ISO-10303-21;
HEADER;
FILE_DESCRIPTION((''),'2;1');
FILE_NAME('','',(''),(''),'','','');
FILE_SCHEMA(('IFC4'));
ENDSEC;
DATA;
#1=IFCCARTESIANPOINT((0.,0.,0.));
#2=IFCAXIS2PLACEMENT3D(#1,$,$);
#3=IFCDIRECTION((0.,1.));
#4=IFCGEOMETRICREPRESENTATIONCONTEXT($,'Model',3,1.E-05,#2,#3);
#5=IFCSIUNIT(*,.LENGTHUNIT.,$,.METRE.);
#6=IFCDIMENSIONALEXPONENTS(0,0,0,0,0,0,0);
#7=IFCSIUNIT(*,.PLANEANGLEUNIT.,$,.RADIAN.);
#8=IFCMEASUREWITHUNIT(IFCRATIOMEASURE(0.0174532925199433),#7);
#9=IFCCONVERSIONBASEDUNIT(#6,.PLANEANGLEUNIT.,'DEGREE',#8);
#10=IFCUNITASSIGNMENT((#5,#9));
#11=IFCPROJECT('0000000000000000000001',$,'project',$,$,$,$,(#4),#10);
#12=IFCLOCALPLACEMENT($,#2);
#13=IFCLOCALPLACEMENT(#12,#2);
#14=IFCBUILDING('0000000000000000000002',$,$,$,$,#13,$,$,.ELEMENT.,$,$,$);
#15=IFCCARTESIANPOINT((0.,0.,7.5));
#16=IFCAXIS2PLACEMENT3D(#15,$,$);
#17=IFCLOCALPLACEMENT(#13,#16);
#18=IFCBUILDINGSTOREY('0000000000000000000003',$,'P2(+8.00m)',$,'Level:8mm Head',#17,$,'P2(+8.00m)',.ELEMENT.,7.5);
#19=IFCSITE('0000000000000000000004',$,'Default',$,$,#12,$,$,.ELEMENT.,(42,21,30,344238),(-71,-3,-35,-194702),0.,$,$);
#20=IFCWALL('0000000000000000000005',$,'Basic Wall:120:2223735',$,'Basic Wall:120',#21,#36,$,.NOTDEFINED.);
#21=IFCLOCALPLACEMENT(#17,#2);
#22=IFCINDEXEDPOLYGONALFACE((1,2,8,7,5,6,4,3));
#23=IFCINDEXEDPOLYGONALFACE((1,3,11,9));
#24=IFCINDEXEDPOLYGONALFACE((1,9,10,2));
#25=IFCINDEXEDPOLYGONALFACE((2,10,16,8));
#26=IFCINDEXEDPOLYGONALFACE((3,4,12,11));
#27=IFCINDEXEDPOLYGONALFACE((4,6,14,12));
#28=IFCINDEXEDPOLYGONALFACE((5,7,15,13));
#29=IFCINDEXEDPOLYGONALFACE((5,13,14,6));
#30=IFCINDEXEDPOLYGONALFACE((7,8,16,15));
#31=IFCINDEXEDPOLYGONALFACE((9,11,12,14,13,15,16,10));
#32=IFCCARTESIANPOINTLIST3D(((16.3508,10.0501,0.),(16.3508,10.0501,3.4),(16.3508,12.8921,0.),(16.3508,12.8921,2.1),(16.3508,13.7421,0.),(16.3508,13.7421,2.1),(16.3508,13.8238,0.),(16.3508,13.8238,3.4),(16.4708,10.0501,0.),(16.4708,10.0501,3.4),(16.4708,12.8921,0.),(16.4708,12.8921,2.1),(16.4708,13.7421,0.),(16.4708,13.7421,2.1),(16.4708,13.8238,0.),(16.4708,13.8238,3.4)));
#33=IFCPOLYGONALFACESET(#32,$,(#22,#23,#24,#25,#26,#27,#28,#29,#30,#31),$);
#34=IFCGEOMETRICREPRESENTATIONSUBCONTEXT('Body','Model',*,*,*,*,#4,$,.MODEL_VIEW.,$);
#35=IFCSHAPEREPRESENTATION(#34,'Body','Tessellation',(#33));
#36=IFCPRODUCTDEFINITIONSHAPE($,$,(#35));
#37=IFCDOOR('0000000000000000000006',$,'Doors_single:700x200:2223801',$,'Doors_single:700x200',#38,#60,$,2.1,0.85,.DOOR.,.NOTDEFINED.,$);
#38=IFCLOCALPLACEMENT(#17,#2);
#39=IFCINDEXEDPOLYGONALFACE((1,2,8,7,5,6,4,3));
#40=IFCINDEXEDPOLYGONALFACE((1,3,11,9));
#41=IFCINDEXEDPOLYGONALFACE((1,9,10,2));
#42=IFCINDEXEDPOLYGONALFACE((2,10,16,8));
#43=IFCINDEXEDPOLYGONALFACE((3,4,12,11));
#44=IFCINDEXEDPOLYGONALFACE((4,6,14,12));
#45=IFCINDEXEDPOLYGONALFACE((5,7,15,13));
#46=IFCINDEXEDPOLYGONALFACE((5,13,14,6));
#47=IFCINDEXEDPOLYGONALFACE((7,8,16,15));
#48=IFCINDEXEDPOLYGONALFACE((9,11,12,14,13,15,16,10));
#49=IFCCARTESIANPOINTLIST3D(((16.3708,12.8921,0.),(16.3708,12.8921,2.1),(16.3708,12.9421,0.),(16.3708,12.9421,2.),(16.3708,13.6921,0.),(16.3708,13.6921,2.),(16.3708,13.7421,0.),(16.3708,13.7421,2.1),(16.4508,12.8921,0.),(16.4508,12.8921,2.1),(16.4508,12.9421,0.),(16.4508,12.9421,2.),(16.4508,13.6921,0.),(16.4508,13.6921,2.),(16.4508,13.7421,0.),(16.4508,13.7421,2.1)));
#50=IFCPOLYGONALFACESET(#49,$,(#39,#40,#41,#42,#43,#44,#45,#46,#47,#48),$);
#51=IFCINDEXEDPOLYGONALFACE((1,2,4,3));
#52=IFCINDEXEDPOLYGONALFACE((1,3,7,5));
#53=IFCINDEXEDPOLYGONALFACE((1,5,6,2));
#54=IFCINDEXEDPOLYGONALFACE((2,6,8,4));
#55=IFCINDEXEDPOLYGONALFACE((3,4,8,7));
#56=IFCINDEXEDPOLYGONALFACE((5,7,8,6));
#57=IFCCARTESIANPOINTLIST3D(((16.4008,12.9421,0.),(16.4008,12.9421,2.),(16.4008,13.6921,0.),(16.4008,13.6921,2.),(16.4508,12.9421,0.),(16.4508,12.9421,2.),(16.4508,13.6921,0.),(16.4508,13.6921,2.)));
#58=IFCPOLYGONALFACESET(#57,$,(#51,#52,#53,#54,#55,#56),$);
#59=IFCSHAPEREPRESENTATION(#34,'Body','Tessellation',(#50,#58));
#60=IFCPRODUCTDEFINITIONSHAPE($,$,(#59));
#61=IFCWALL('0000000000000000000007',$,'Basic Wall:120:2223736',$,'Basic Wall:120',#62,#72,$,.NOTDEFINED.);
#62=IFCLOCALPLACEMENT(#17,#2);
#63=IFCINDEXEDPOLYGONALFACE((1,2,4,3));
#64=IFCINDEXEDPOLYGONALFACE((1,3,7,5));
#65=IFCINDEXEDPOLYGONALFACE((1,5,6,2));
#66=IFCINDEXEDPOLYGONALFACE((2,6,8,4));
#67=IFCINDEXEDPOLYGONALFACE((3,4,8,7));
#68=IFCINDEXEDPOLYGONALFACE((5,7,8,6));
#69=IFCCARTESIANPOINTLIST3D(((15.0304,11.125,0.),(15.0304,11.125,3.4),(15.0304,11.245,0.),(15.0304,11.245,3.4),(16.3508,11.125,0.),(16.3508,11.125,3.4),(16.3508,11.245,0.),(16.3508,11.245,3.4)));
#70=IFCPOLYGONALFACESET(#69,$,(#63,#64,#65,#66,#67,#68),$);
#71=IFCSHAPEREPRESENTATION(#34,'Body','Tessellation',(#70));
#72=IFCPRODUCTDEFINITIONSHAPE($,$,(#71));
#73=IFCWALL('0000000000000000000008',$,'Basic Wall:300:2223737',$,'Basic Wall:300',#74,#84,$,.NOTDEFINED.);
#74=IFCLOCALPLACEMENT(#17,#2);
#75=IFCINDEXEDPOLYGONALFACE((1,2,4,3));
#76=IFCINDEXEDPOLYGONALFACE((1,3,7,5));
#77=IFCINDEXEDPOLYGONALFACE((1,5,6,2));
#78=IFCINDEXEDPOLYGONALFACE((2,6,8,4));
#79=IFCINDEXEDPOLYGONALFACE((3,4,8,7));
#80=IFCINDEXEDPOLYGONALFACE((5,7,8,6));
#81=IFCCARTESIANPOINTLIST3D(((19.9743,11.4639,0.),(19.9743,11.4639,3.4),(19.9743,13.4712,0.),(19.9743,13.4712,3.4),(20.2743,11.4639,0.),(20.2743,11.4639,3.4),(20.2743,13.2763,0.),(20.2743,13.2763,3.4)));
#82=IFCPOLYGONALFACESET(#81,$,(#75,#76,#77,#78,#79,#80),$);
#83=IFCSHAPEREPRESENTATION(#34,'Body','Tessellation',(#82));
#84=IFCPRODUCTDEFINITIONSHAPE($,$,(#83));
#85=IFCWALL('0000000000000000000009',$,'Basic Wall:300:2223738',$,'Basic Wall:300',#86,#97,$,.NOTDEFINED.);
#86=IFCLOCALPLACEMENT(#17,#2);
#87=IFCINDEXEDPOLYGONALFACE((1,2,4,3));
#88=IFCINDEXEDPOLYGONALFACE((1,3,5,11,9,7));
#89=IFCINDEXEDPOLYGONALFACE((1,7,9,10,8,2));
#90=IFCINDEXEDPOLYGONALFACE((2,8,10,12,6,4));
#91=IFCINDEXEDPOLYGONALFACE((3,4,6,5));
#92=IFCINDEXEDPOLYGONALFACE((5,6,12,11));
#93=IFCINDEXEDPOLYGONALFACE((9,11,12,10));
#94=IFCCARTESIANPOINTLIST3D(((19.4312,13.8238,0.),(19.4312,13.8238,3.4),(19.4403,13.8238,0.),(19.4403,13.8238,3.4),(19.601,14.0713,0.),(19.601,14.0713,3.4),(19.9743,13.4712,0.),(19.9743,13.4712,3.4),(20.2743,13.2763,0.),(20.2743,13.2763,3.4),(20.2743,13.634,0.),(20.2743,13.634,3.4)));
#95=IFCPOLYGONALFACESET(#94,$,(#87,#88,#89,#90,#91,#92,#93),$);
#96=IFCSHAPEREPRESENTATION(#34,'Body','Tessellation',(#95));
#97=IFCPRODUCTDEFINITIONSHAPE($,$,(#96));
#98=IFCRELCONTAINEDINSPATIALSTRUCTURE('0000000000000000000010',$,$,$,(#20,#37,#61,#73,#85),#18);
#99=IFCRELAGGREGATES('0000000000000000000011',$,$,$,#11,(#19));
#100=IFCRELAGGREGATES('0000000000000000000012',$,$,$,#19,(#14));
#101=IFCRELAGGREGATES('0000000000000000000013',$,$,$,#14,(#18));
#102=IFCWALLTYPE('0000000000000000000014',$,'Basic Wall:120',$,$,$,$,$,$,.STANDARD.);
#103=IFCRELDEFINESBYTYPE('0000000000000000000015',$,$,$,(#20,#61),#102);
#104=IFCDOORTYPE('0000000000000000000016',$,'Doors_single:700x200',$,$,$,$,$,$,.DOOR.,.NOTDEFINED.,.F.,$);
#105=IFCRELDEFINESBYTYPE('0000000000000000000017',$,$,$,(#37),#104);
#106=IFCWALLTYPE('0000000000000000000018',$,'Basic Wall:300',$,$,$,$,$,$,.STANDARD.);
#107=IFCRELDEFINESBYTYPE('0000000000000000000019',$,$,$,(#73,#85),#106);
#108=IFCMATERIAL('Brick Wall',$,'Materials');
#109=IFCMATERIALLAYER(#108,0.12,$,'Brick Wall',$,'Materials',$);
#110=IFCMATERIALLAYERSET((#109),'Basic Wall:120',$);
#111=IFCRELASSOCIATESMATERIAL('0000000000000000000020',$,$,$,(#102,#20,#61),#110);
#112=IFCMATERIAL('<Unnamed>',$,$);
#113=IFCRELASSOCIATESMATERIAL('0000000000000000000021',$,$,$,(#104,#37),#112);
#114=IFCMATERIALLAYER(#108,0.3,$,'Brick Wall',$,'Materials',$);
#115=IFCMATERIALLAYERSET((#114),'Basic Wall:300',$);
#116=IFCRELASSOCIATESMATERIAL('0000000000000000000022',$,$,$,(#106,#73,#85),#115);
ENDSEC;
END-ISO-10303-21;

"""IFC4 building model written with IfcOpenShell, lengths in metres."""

from ifc_helpers import new_model, entity, si_unit, converted_unit, direction, frame, frame_2d, origin, origin_2d_with_axis, place, context, subcontext, project, spatial, polyline, rectangle, outline, extrude, source, transform, mapped, material, layer, layer_set, layer_usage, type_object, type_shapes, element, fill, save


model = new_model("IFC4")

# Units and contexts
model_context = context("Model", 3, precision=1e-05, world=origin(), true_north=direction((0.0, 1.0)))
body_context = subcontext(model_context, "Body", "Model", "MODEL_VIEW")
ifc_project = project(units=[si_unit("LENGTHUNIT", "METRE"), converted_unit("PLANEANGLEUNIT", "DEGREE", entity("IfcRatioMeasure", 0.0174532925199433), si_unit("PLANEANGLEUNIT", "RADIAN"), dimensions=[0, 0, 0, 0, 0, 0, 0])], contexts=[model_context])

# Site, building, storey
site_placement = place(None, origin())
site = spatial("IfcSite", under=ifc_project, at=site_placement, Name="Default", CompositionType="ELEMENT", RefLatitude=(42, 21, 30, 344238), RefLongitude=(-71, -3, -35, -194702), RefElevation=0.0)
building_placement = place(site_placement, origin())
building = spatial("IfcBuilding", under=site, at=building_placement, CompositionType="ELEMENT")
storey_placement = place(building_placement, frame((0.0, 0.0, 7.5)))
storey = spatial("IfcBuildingStorey", under=building, at=storey_placement, Name="P2(+8.00m)", ObjectType="Level:8mm Head", LongName="P2(+8.00m)", CompositionType="ELEMENT", Elevation=7.5)

# Shared definitions
ifc_material_1 = material(Name="Brick Wall", Category="Materials")

# Shared definitions
ifc_material_2 = material(Name="<Unnamed>")

# Wall, opening, door
ifc_layer_1 = layer(ifc_material_1, 0.12, Name="Brick Wall", Category="Materials")
ifc_layer_set_1 = layer_set([ifc_layer_1], Name="Basic Wall:120")
ifc_layer_usage_1 = layer_usage(ifc_layer_set_1, "AXIS2", "POSITIVE", -0.06)
wall_type_1 = type_object("IfcWallType", Name="Basic Wall:120", PredefinedType="STANDARD", material=ifc_layer_set_1)
wall_1_placement = place(storey_placement, frame((16.4108, 10.0501, 0.0), z_axis=(0.0, 0.0, 1.0), x_axis=(0.0, 1.0, 0.0)))
wall_1 = element("IfcWall", 1, at=wall_1_placement, inside=storey, type_object=wall_type_1, material=ifc_layer_usage_1, Name="Basic Wall:120:2223735", ObjectType="Basic Wall:120", PredefinedType="NOTDEFINED", context=body_context, shape_type="SweptSolid", body=[
    extrude(rectangle(XDim=3.7738, YDim=0.12, at=frame_2d((1.8869, 0.0), x_axis=(-1.0, 0.0))), origin(), (0.0, 0.0, 1.0), 3.4),
])
opening_1_placement = place(wall_1_placement, frame((3.6921, 0.06, 0.0)))
opening_1 = element("IfcOpeningElement", 2, at=opening_1_placement, cuts=wall_1, PredefinedType="OPENING", context=body_context, shape_type="SweptSolid", body=[
    extrude(rectangle(XDim=2.1, YDim=0.85, at=frame_2d((1.05, 0.425), x_axis=(1.0, 0.0))), frame((0.0, 0.0, 0.0), z_axis=(0.0, -1.0, 0.0), x_axis=(0.0, 0.0, 1.0)), (0.0, 0.0, 1.0), 0.12),
])
door_type_1 = type_object("IfcDoorType", Name="Doors_single:700x200", OperationType="NOTDEFINED", ParameterTakesPrecedence=False, PredefinedType="DOOR", material=ifc_material_2)
shared_shape_1 = source(origin(), body_context, "Body", "SweptSolid", [
    extrude(outline(polyline([(-0.425, -1.025), (-0.375, -1.025), (-0.375, 0.975), (0.375, 0.975), (0.375, -1.025), (0.425, -1.025), (0.425, 1.075), (-0.425, 1.075), (-0.425, -1.025)])), frame((0.425, 0.02, 1.025), z_axis=(0.0, 1.0, 0.0), x_axis=(-1.0, 0.0, 0.0)), (0.0, 0.0, 1.0), 0.08),
    extrude(rectangle(XDim=0.75, YDim=0.05, at=origin_2d_with_axis()), frame((0.425, 0.075, 0.0), z_axis=(0.0, 0.0, 1.0), x_axis=(-1.0, 0.0, 0.0)), (0.0, 0.0, 1.0), 2.0),
])
type_shapes(door_type_1, [shared_shape_1])
door_1_placement = place(opening_1_placement, frame((0.0, 0.0, 0.0), z_axis=(0.0, 0.0, 1.0), x_axis=(-1.0, 0.0, 0.0)))
door_1 = element("IfcDoor", 3, at=door_1_placement, inside=storey, type_object=door_type_1, material=ifc_material_2, Name="Doors_single:700x200:2223801", ObjectType="Doors_single:700x200", OperationType="NOTDEFINED", OverallHeight=2.1, OverallWidth=0.85, PredefinedType="DOOR", context=body_context, shape_type="MappedRepresentation", body=[
    mapped(shared_shape_1, transform((0.0, 0.0, 0.0), scale=1.0)),
])
fill(opening_1, door_1)

# Walls
ifc_layer_usage_2 = layer_usage(ifc_layer_set_1, "AXIS2", "POSITIVE", -0.06)
wall_2_placement = place(storey_placement, frame((16.3508, 11.185, 0.0), z_axis=(0.0, 0.0, 1.0), x_axis=(-1.0, 0.0, 0.0)))
element("IfcWall", 4, at=wall_2_placement, inside=storey, type_object=wall_type_1, material=ifc_layer_usage_2, Name="Basic Wall:120:2223736", ObjectType="Basic Wall:120", PredefinedType="NOTDEFINED", context=body_context, shape_type="SweptSolid", body=[
    extrude(rectangle(XDim=1.3204, YDim=0.12, at=frame_2d((0.6602, 0.0), x_axis=(-1.0, 0.0))), origin(), (0.0, 0.0, 1.0), 3.4),
])
ifc_layer_2 = layer(ifc_material_1, 0.3, Name="Brick Wall", Category="Materials")
ifc_layer_set_2 = layer_set([ifc_layer_2], Name="Basic Wall:300")
ifc_layer_usage_3 = layer_usage(ifc_layer_set_2, "AXIS2", "POSITIVE", -0.15)
wall_type_2 = type_object("IfcWallType", Name="Basic Wall:300", PredefinedType="STANDARD", material=ifc_layer_set_2)
wall_3_placement = place(storey_placement, frame((20.1243, 11.4639, 0.0), z_axis=(0.0, 0.0, 1.0), x_axis=(0.0, 1.0, 0.0)))
element("IfcWall", 5, at=wall_3_placement, inside=storey, type_object=wall_type_2, material=ifc_layer_usage_3, Name="Basic Wall:300:2223737", ObjectType="Basic Wall:300", PredefinedType="NOTDEFINED", context=body_context, shape_type="SweptSolid", body=[
    extrude(outline(polyline([(1.8124, -0.15), (2.0072, 0.15), (0.0, 0.15), (0.0, -0.15), (1.8124, -0.15)])), origin(), (0.0, 0.0, 1.0), 3.4),
])
ifc_layer_usage_4 = layer_usage(ifc_layer_set_2, "AXIS2", "POSITIVE", -0.15)
wall_4_placement = place(storey_placement, frame((20.356, 13.4021, 0.0), z_axis=(0.0, 0.0, 1.0), x_axis=(-0.838671, 0.544639, 0.0)))
element("IfcWall", 6, at=wall_4_placement, inside=storey, type_object=wall_type_2, material=ifc_layer_usage_4, Name="Basic Wall:300:2223738", ObjectType="Basic Wall:300", PredefinedType="NOTDEFINED", context=body_context, shape_type="SweptSolid", body=[
    extrude(outline(polyline([(0.9976, -0.15), (0.9976, 0.1451), (1.0052, 0.15), (0.3577, 0.15), (0.0, 0.15), (0.1948, -0.15), (0.9976, -0.15)])), origin(), (0.0, 0.0, 1.0), 3.4),
])

save(model, "model.ifc")
